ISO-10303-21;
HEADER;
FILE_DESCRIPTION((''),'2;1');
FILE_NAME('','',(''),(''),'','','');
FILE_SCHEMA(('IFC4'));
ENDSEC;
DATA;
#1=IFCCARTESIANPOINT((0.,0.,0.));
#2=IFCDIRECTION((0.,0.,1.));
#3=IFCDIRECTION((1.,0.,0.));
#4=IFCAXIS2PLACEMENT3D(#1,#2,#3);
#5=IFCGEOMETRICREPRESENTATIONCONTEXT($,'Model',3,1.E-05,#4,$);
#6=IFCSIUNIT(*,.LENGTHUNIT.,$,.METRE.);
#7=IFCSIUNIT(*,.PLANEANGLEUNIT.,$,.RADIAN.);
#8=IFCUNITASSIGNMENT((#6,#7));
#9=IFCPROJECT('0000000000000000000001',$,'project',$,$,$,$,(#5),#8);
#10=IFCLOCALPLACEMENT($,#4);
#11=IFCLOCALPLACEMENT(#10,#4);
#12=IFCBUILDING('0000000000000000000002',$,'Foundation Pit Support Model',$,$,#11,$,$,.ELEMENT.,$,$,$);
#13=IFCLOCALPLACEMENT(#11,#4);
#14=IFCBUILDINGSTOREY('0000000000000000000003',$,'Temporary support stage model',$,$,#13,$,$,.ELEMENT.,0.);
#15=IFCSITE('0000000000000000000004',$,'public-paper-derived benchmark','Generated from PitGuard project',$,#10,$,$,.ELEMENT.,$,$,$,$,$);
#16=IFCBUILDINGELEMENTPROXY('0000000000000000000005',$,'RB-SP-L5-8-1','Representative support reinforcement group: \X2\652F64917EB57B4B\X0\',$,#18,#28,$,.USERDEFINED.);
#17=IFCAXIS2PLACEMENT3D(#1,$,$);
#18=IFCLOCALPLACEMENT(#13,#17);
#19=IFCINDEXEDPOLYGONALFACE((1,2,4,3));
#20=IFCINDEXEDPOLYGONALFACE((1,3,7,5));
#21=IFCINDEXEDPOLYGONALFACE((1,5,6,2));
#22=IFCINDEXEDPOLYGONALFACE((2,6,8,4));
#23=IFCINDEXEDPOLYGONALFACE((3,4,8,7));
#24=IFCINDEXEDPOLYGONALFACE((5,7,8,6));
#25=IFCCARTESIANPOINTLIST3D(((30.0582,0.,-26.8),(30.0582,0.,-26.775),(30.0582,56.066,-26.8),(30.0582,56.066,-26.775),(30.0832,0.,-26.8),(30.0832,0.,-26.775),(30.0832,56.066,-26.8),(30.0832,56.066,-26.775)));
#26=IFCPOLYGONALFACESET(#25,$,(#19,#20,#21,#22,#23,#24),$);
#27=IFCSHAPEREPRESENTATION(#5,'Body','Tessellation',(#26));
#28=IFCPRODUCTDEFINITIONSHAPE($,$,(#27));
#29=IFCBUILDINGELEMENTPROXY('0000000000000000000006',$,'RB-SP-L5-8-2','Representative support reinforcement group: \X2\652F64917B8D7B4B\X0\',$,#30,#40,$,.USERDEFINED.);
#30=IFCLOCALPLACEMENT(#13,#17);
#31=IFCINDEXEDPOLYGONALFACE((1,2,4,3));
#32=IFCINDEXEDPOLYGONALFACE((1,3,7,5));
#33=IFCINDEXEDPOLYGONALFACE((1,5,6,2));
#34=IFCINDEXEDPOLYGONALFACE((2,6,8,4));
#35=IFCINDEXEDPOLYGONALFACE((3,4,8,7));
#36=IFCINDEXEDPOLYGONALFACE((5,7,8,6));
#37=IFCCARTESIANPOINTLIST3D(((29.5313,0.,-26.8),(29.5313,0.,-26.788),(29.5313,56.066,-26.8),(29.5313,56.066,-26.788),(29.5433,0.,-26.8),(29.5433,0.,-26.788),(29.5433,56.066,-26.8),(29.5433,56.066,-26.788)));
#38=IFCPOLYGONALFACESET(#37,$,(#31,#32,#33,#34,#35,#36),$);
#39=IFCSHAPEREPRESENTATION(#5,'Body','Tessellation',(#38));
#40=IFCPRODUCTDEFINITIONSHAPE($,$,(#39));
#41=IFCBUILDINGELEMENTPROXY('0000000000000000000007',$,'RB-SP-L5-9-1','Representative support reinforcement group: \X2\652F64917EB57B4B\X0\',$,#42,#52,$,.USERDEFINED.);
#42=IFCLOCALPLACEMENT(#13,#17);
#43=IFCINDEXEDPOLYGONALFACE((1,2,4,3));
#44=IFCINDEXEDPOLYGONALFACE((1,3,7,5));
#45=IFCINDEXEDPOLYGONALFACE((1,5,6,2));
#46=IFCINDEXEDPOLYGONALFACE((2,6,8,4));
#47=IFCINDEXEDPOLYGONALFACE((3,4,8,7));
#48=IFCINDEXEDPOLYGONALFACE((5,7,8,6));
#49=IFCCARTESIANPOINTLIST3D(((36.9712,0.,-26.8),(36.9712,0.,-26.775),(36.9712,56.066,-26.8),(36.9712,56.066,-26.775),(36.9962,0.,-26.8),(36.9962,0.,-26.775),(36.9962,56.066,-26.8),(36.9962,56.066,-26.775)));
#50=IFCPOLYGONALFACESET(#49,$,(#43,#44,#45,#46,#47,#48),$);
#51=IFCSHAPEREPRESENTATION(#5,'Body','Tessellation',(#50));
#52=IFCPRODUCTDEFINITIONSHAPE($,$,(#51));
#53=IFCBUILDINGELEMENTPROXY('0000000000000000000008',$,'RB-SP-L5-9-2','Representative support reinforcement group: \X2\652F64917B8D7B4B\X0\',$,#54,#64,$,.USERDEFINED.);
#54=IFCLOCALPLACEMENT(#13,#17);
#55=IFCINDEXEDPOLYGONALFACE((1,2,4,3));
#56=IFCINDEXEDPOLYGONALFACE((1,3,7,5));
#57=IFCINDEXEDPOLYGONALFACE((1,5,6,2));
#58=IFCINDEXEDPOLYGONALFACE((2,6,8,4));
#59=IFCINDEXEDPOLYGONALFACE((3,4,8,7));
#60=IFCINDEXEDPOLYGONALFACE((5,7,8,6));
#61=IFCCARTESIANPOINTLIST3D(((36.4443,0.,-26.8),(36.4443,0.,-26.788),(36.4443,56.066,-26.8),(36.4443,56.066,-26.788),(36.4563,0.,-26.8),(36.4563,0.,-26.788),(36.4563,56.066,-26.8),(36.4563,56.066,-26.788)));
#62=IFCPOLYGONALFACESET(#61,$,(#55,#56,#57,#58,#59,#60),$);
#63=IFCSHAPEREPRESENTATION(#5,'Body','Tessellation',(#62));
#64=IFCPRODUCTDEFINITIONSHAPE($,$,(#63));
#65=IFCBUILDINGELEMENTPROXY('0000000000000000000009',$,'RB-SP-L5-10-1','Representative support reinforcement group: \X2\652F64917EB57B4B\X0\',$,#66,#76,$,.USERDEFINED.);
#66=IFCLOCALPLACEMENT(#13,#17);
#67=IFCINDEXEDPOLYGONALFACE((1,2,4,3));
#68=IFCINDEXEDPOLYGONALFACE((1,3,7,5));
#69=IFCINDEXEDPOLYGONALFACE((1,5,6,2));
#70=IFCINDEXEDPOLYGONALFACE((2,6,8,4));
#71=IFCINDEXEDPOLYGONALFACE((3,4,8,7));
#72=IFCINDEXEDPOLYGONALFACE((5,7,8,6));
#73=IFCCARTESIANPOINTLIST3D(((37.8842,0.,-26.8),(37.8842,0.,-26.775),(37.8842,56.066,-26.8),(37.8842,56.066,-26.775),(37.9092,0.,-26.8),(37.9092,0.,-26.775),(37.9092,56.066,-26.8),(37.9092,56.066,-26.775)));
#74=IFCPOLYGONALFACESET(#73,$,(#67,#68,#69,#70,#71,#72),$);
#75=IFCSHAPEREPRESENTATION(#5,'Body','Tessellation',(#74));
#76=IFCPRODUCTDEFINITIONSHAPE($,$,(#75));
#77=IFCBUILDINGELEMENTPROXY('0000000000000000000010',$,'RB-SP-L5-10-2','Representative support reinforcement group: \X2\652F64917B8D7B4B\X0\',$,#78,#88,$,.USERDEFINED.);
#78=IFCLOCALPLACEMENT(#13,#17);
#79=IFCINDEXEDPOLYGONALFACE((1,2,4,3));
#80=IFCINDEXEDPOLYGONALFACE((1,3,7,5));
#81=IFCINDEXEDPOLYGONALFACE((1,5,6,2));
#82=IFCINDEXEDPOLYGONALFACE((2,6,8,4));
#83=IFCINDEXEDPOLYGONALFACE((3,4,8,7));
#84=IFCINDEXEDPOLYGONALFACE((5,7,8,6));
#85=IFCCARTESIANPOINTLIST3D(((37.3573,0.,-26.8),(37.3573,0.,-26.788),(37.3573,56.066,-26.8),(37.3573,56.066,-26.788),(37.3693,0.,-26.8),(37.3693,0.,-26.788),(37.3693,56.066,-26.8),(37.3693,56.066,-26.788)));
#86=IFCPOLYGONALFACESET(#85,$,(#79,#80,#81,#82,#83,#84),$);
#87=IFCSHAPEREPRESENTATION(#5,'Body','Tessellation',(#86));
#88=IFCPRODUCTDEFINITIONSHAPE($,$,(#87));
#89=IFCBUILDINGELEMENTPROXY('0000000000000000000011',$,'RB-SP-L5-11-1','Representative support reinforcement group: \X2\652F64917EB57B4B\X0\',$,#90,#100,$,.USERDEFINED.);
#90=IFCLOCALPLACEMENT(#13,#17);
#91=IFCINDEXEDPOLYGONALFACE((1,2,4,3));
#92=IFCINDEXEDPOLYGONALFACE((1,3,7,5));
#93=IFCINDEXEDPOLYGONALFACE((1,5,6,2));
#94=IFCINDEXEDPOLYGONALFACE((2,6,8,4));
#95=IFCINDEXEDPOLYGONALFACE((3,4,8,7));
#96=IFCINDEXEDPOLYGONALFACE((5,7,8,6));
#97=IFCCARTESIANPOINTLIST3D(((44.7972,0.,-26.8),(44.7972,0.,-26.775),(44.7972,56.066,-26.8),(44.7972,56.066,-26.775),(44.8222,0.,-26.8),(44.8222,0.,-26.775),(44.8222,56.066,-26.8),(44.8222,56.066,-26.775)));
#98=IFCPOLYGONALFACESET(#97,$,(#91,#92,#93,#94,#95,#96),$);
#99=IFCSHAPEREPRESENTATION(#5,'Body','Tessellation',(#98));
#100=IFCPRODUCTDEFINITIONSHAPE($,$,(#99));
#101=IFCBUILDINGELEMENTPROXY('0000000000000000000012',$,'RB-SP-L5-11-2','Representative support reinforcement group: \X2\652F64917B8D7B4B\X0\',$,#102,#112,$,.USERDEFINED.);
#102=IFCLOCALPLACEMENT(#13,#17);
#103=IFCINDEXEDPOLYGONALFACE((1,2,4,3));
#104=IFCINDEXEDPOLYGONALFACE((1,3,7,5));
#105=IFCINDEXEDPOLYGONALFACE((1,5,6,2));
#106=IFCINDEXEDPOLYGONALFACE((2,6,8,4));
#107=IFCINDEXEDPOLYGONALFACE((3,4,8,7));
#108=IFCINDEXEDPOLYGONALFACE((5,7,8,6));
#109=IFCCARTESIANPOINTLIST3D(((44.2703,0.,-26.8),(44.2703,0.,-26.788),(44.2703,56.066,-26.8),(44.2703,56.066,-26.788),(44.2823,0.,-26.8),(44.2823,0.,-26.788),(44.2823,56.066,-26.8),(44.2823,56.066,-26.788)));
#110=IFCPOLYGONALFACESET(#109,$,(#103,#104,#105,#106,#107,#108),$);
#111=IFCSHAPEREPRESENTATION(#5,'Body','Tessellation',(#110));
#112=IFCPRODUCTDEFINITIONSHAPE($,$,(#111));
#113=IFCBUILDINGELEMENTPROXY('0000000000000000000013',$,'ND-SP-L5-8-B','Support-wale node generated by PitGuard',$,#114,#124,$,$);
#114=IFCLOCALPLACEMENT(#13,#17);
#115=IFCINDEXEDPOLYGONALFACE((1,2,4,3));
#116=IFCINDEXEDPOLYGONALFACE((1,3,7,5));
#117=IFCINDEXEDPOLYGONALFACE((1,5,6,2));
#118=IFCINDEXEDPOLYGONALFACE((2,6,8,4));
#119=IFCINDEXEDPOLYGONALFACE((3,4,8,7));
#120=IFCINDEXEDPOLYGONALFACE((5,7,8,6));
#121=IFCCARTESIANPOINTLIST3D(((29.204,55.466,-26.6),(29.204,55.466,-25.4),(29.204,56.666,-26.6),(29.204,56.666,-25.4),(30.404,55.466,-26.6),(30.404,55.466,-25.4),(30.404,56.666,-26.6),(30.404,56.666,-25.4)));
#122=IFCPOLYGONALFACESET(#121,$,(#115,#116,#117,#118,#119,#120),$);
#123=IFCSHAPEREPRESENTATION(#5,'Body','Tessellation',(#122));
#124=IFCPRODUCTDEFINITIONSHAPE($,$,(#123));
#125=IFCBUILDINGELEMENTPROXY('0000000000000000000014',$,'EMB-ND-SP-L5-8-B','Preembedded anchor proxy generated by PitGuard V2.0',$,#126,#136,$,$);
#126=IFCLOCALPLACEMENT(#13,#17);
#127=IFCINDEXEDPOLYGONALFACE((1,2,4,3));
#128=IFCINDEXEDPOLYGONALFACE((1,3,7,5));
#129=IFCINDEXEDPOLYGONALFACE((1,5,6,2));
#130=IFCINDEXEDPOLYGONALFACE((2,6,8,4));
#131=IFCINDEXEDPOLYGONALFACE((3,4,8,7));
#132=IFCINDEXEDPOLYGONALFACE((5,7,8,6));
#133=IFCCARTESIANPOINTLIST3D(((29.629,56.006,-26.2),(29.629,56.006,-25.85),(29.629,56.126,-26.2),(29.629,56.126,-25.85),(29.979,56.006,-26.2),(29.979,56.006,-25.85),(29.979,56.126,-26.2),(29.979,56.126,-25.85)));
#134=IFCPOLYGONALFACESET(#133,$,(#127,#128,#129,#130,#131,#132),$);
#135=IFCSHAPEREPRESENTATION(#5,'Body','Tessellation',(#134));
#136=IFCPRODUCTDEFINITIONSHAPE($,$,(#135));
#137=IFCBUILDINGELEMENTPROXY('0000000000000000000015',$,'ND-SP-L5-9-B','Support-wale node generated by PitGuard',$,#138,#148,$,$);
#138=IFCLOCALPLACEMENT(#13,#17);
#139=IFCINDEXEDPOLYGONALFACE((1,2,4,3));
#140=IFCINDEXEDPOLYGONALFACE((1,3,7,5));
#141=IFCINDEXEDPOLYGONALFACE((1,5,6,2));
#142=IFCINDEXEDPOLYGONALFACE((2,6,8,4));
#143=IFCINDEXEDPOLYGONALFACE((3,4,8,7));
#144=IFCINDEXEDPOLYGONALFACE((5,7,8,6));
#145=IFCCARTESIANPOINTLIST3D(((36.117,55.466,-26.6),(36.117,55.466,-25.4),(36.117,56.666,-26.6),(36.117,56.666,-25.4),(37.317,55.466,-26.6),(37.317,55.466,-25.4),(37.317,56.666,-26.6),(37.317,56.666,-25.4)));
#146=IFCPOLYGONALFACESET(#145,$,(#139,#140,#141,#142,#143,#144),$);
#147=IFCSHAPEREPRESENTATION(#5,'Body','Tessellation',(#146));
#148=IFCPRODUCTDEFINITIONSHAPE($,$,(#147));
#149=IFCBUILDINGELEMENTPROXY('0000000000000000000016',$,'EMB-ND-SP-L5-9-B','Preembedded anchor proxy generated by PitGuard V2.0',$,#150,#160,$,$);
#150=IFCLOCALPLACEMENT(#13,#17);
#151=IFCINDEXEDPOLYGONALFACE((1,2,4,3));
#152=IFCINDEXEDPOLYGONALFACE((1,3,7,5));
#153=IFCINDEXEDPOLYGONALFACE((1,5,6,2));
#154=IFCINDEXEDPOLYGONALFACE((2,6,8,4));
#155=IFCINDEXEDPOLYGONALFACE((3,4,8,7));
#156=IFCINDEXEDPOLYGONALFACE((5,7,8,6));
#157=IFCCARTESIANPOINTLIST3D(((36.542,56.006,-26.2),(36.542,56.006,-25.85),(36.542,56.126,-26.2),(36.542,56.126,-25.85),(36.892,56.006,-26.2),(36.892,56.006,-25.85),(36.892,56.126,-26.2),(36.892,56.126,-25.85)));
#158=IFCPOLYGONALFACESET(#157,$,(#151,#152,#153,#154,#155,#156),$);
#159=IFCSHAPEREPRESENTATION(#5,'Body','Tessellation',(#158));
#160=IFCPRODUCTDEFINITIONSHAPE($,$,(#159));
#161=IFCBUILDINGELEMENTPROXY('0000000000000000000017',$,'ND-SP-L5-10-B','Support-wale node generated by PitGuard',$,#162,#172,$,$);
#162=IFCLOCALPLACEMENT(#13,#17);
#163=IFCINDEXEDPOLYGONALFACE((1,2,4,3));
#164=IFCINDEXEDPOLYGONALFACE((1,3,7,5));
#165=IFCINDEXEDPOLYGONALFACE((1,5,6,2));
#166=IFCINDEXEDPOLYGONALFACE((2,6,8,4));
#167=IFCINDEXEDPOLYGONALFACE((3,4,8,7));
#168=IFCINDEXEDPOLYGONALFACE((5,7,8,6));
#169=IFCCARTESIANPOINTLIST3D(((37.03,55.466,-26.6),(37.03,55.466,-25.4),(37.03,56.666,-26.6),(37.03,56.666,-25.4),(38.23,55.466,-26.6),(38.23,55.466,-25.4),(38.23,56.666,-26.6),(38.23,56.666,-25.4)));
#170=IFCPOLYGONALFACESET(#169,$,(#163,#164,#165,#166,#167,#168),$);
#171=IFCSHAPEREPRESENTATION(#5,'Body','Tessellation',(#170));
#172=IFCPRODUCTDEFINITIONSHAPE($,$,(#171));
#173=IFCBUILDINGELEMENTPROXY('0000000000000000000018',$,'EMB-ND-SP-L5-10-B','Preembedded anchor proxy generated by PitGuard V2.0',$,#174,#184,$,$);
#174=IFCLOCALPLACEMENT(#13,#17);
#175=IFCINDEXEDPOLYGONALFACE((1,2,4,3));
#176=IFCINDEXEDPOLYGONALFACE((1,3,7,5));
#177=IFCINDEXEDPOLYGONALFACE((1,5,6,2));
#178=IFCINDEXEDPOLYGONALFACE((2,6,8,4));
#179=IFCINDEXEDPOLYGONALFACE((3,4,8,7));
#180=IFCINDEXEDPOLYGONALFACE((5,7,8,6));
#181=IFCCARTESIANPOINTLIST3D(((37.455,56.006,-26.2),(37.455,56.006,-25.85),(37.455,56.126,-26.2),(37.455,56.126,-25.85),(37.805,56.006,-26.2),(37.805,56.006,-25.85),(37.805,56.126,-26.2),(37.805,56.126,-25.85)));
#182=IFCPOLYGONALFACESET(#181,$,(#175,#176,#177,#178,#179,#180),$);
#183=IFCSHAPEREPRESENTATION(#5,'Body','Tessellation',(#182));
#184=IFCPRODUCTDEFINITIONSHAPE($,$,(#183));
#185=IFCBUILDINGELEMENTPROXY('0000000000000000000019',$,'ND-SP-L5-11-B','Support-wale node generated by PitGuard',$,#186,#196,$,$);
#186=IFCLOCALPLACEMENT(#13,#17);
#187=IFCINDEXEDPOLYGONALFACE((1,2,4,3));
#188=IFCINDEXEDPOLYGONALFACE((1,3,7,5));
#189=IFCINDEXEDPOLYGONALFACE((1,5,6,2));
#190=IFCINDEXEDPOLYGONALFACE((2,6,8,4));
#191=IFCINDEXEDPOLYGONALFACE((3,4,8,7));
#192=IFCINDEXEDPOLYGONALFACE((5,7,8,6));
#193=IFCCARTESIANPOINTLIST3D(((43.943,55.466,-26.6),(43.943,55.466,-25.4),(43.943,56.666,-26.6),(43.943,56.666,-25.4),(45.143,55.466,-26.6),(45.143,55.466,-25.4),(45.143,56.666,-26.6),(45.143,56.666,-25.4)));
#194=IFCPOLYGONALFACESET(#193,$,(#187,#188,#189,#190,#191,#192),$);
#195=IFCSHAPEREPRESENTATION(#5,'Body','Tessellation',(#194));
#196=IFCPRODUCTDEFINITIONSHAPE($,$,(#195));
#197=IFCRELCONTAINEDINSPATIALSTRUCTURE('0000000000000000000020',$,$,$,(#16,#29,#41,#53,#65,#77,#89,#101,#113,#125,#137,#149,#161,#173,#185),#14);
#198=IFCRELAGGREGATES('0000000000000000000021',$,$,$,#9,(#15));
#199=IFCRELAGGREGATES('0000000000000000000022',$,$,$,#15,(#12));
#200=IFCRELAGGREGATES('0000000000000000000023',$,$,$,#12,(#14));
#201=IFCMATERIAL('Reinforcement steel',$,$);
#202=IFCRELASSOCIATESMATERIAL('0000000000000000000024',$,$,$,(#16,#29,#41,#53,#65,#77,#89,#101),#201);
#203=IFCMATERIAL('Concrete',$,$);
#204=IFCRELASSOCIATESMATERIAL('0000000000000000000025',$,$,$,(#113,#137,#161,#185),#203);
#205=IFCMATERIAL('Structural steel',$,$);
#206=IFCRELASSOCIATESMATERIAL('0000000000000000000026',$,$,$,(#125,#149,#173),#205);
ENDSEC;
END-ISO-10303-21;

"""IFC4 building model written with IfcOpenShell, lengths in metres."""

from ifc_helpers import new_model, si_unit, frame, origin_with_axes, origin_2d, place, context, project, spatial, rectangle, extrude, material, element, save


model = new_model("IFC4")

# Units and contexts
model_context = context("Model", 3, precision=1e-05, world=origin_with_axes())
ifc_project = project(units=[si_unit("LENGTHUNIT", "METRE"), si_unit("PLANEANGLEUNIT", "RADIAN")], contexts=[model_context])

# Site, building, storey
site_placement = place(None, origin_with_axes())
site = spatial("IfcSite", under=ifc_project, at=site_placement, Name="public-paper-derived benchmark", Description="Generated from PitGuard project", CompositionType="ELEMENT")
building_placement = place(site_placement, origin_with_axes())
building = spatial("IfcBuilding", under=site, at=building_placement, Name="Foundation Pit Support Model", CompositionType="ELEMENT")
storey_placement = place(building_placement, origin_with_axes())
storey = spatial("IfcBuildingStorey", under=building, at=storey_placement, Name="Temporary support stage model", CompositionType="ELEMENT", Elevation=0.0)

# Shared definitions
ifc_material_1 = material(Name="Structural steel")

# Shared definitions
ifc_material_2 = material(Name="Concrete")

# Building element proxies
ifc_material_3 = material(Name="Reinforcement steel")
proxy_1_placement = place(storey_placement, frame((30.0707, 28.033, -26.8), z_axis=(0.0, 0.0, 1.0), x_axis=(0.0, 1.0, 0.0)))
element("IfcBuildingElementProxy", 1, at=proxy_1_placement, inside=storey, material=ifc_material_3, Name="RB-SP-L5-8-1", Description="Representative support reinforcement group: 支撑纵筋", PredefinedType="USERDEFINED", context=model_context, shape_type="SweptSolid", body=[
    extrude(rectangle(XDim=56.066, YDim=0.025, at=origin_2d()), origin_with_axes(), (0.0, 0.0, 1.0), 0.025),
])
proxy_2_placement = place(storey_placement, frame((29.5373, 28.033, -26.8), z_axis=(0.0, 0.0, 1.0), x_axis=(0.0, 1.0, 0.0)))
element("IfcBuildingElementProxy", 2, at=proxy_2_placement, inside=storey, material=ifc_material_3, Name="RB-SP-L5-8-2", Description="Representative support reinforcement group: 支撑箍筋", PredefinedType="USERDEFINED", context=model_context, shape_type="SweptSolid", body=[
    extrude(rectangle(XDim=56.066, YDim=0.012, at=origin_2d()), origin_with_axes(), (0.0, 0.0, 1.0), 0.012),
])
proxy_3_placement = place(storey_placement, frame((36.9837, 28.033, -26.8), z_axis=(0.0, 0.0, 1.0), x_axis=(0.0, 1.0, 0.0)))
element("IfcBuildingElementProxy", 3, at=proxy_3_placement, inside=storey, material=ifc_material_3, Name="RB-SP-L5-9-1", Description="Representative support reinforcement group: 支撑纵筋", PredefinedType="USERDEFINED", context=model_context, shape_type="SweptSolid", body=[
    extrude(rectangle(XDim=56.066, YDim=0.025, at=origin_2d()), origin_with_axes(), (0.0, 0.0, 1.0), 0.025),
])
proxy_4_placement = place(storey_placement, frame((36.4503, 28.033, -26.8), z_axis=(0.0, 0.0, 1.0), x_axis=(0.0, 1.0, 0.0)))
element("IfcBuildingElementProxy", 4, at=proxy_4_placement, inside=storey, material=ifc_material_3, Name="RB-SP-L5-9-2", Description="Representative support reinforcement group: 支撑箍筋", PredefinedType="USERDEFINED", context=model_context, shape_type="SweptSolid", body=[
    extrude(rectangle(XDim=56.066, YDim=0.012, at=origin_2d()), origin_with_axes(), (0.0, 0.0, 1.0), 0.012),
])
proxy_5_placement = place(storey_placement, frame((37.8967, 28.033, -26.8), z_axis=(0.0, 0.0, 1.0), x_axis=(0.0, 1.0, 0.0)))
element("IfcBuildingElementProxy", 5, at=proxy_5_placement, inside=storey, material=ifc_material_3, Name="RB-SP-L5-10-1", Description="Representative support reinforcement group: 支撑纵筋", PredefinedType="USERDEFINED", context=model_context, shape_type="SweptSolid", body=[
    extrude(rectangle(XDim=56.066, YDim=0.025, at=origin_2d()), origin_with_axes(), (0.0, 0.0, 1.0), 0.025),
])
proxy_6_placement = place(storey_placement, frame((37.3633, 28.033, -26.8), z_axis=(0.0, 0.0, 1.0), x_axis=(0.0, 1.0, 0.0)))
element("IfcBuildingElementProxy", 6, at=proxy_6_placement, inside=storey, material=ifc_material_3, Name="RB-SP-L5-10-2", Description="Representative support reinforcement group: 支撑箍筋", PredefinedType="USERDEFINED", context=model_context, shape_type="SweptSolid", body=[
    extrude(rectangle(XDim=56.066, YDim=0.012, at=origin_2d()), origin_with_axes(), (0.0, 0.0, 1.0), 0.012),
])
proxy_7_placement = place(storey_placement, frame((44.8097, 28.033, -26.8), z_axis=(0.0, 0.0, 1.0), x_axis=(0.0, 1.0, 0.0)))
element("IfcBuildingElementProxy", 7, at=proxy_7_placement, inside=storey, material=ifc_material_3, Name="RB-SP-L5-11-1", Description="Representative support reinforcement group: 支撑纵筋", PredefinedType="USERDEFINED", context=model_context, shape_type="SweptSolid", body=[
    extrude(rectangle(XDim=56.066, YDim=0.025, at=origin_2d()), origin_with_axes(), (0.0, 0.0, 1.0), 0.025),
])
proxy_8_placement = place(storey_placement, frame((44.2763, 28.033, -26.8), z_axis=(0.0, 0.0, 1.0), x_axis=(0.0, 1.0, 0.0)))
element("IfcBuildingElementProxy", 8, at=proxy_8_placement, inside=storey, material=ifc_material_3, Name="RB-SP-L5-11-2", Description="Representative support reinforcement group: 支撑箍筋", PredefinedType="USERDEFINED", context=model_context, shape_type="SweptSolid", body=[
    extrude(rectangle(XDim=56.066, YDim=0.012, at=origin_2d()), origin_with_axes(), (0.0, 0.0, 1.0), 0.012),
])
proxy_9_placement = place(storey_placement, frame((29.804, 56.066, -26.6), z_axis=(0.0, 0.0, 1.0), x_axis=(1.0, 0.0, 0.0)))
element("IfcBuildingElementProxy", 9, at=proxy_9_placement, inside=storey, material=ifc_material_2, Name="ND-SP-L5-8-B", Description="Support-wale node generated by PitGuard", context=model_context, shape_type="SweptSolid", body=[
    extrude(rectangle(XDim=1.2, YDim=1.2, at=origin_2d()), origin_with_axes(), (0.0, 0.0, 1.0), 1.2),
])
proxy_10_placement = place(storey_placement, frame((29.804, 56.066, -26.2), z_axis=(0.0, 0.0, 1.0), x_axis=(1.0, 0.0, 0.0)))
element("IfcBuildingElementProxy", 10, at=proxy_10_placement, inside=storey, material=ifc_material_1, Name="EMB-ND-SP-L5-8-B", Description="Preembedded anchor proxy generated by PitGuard V2.0", context=model_context, shape_type="SweptSolid", body=[
    extrude(rectangle(XDim=0.35, YDim=0.12, at=origin_2d()), origin_with_axes(), (0.0, 0.0, 1.0), 0.35),
])
proxy_11_placement = place(storey_placement, frame((36.717, 56.066, -26.6), z_axis=(0.0, 0.0, 1.0), x_axis=(1.0, 0.0, 0.0)))
element("IfcBuildingElementProxy", 11, at=proxy_11_placement, inside=storey, material=ifc_material_2, Name="ND-SP-L5-9-B", Description="Support-wale node generated by PitGuard", context=model_context, shape_type="SweptSolid", body=[
    extrude(rectangle(XDim=1.2, YDim=1.2, at=origin_2d()), origin_with_axes(), (0.0, 0.0, 1.0), 1.2),
])
proxy_12_placement = place(storey_placement, frame((36.717, 56.066, -26.2), z_axis=(0.0, 0.0, 1.0), x_axis=(1.0, 0.0, 0.0)))
element("IfcBuildingElementProxy", 12, at=proxy_12_placement, inside=storey, material=ifc_material_1, Name="EMB-ND-SP-L5-9-B", Description="Preembedded anchor proxy generated by PitGuard V2.0", context=model_context, shape_type="SweptSolid", body=[
    extrude(rectangle(XDim=0.35, YDim=0.12, at=origin_2d()), origin_with_axes(), (0.0, 0.0, 1.0), 0.35),
])
proxy_13_placement = place(storey_placement, frame((37.63, 56.066, -26.6), z_axis=(0.0, 0.0, 1.0), x_axis=(1.0, 0.0, 0.0)))
element("IfcBuildingElementProxy", 13, at=proxy_13_placement, inside=storey, material=ifc_material_2, Name="ND-SP-L5-10-B", Description="Support-wale node generated by PitGuard", context=model_context, shape_type="SweptSolid", body=[
    extrude(rectangle(XDim=1.2, YDim=1.2, at=origin_2d()), origin_with_axes(), (0.0, 0.0, 1.0), 1.2),
])
proxy_14_placement = place(storey_placement, frame((37.63, 56.066, -26.2), z_axis=(0.0, 0.0, 1.0), x_axis=(1.0, 0.0, 0.0)))
element("IfcBuildingElementProxy", 14, at=proxy_14_placement, inside=storey, material=ifc_material_1, Name="EMB-ND-SP-L5-10-B", Description="Preembedded anchor proxy generated by PitGuard V2.0", context=model_context, shape_type="SweptSolid", body=[
    extrude(rectangle(XDim=0.35, YDim=0.12, at=origin_2d()), origin_with_axes(), (0.0, 0.0, 1.0), 0.35),
])
proxy_15_placement = place(storey_placement, frame((44.543, 56.066, -26.6), z_axis=(0.0, 0.0, 1.0), x_axis=(1.0, 0.0, 0.0)))
element("IfcBuildingElementProxy", 15, at=proxy_15_placement, inside=storey, material=ifc_material_2, Name="ND-SP-L5-11-B", Description="Support-wale node generated by PitGuard", context=model_context, shape_type="SweptSolid", body=[
    extrude(rectangle(XDim=1.2, YDim=1.2, at=origin_2d()), origin_with_axes(), (0.0, 0.0, 1.0), 1.2),
])

save(model, "model.ifc")
